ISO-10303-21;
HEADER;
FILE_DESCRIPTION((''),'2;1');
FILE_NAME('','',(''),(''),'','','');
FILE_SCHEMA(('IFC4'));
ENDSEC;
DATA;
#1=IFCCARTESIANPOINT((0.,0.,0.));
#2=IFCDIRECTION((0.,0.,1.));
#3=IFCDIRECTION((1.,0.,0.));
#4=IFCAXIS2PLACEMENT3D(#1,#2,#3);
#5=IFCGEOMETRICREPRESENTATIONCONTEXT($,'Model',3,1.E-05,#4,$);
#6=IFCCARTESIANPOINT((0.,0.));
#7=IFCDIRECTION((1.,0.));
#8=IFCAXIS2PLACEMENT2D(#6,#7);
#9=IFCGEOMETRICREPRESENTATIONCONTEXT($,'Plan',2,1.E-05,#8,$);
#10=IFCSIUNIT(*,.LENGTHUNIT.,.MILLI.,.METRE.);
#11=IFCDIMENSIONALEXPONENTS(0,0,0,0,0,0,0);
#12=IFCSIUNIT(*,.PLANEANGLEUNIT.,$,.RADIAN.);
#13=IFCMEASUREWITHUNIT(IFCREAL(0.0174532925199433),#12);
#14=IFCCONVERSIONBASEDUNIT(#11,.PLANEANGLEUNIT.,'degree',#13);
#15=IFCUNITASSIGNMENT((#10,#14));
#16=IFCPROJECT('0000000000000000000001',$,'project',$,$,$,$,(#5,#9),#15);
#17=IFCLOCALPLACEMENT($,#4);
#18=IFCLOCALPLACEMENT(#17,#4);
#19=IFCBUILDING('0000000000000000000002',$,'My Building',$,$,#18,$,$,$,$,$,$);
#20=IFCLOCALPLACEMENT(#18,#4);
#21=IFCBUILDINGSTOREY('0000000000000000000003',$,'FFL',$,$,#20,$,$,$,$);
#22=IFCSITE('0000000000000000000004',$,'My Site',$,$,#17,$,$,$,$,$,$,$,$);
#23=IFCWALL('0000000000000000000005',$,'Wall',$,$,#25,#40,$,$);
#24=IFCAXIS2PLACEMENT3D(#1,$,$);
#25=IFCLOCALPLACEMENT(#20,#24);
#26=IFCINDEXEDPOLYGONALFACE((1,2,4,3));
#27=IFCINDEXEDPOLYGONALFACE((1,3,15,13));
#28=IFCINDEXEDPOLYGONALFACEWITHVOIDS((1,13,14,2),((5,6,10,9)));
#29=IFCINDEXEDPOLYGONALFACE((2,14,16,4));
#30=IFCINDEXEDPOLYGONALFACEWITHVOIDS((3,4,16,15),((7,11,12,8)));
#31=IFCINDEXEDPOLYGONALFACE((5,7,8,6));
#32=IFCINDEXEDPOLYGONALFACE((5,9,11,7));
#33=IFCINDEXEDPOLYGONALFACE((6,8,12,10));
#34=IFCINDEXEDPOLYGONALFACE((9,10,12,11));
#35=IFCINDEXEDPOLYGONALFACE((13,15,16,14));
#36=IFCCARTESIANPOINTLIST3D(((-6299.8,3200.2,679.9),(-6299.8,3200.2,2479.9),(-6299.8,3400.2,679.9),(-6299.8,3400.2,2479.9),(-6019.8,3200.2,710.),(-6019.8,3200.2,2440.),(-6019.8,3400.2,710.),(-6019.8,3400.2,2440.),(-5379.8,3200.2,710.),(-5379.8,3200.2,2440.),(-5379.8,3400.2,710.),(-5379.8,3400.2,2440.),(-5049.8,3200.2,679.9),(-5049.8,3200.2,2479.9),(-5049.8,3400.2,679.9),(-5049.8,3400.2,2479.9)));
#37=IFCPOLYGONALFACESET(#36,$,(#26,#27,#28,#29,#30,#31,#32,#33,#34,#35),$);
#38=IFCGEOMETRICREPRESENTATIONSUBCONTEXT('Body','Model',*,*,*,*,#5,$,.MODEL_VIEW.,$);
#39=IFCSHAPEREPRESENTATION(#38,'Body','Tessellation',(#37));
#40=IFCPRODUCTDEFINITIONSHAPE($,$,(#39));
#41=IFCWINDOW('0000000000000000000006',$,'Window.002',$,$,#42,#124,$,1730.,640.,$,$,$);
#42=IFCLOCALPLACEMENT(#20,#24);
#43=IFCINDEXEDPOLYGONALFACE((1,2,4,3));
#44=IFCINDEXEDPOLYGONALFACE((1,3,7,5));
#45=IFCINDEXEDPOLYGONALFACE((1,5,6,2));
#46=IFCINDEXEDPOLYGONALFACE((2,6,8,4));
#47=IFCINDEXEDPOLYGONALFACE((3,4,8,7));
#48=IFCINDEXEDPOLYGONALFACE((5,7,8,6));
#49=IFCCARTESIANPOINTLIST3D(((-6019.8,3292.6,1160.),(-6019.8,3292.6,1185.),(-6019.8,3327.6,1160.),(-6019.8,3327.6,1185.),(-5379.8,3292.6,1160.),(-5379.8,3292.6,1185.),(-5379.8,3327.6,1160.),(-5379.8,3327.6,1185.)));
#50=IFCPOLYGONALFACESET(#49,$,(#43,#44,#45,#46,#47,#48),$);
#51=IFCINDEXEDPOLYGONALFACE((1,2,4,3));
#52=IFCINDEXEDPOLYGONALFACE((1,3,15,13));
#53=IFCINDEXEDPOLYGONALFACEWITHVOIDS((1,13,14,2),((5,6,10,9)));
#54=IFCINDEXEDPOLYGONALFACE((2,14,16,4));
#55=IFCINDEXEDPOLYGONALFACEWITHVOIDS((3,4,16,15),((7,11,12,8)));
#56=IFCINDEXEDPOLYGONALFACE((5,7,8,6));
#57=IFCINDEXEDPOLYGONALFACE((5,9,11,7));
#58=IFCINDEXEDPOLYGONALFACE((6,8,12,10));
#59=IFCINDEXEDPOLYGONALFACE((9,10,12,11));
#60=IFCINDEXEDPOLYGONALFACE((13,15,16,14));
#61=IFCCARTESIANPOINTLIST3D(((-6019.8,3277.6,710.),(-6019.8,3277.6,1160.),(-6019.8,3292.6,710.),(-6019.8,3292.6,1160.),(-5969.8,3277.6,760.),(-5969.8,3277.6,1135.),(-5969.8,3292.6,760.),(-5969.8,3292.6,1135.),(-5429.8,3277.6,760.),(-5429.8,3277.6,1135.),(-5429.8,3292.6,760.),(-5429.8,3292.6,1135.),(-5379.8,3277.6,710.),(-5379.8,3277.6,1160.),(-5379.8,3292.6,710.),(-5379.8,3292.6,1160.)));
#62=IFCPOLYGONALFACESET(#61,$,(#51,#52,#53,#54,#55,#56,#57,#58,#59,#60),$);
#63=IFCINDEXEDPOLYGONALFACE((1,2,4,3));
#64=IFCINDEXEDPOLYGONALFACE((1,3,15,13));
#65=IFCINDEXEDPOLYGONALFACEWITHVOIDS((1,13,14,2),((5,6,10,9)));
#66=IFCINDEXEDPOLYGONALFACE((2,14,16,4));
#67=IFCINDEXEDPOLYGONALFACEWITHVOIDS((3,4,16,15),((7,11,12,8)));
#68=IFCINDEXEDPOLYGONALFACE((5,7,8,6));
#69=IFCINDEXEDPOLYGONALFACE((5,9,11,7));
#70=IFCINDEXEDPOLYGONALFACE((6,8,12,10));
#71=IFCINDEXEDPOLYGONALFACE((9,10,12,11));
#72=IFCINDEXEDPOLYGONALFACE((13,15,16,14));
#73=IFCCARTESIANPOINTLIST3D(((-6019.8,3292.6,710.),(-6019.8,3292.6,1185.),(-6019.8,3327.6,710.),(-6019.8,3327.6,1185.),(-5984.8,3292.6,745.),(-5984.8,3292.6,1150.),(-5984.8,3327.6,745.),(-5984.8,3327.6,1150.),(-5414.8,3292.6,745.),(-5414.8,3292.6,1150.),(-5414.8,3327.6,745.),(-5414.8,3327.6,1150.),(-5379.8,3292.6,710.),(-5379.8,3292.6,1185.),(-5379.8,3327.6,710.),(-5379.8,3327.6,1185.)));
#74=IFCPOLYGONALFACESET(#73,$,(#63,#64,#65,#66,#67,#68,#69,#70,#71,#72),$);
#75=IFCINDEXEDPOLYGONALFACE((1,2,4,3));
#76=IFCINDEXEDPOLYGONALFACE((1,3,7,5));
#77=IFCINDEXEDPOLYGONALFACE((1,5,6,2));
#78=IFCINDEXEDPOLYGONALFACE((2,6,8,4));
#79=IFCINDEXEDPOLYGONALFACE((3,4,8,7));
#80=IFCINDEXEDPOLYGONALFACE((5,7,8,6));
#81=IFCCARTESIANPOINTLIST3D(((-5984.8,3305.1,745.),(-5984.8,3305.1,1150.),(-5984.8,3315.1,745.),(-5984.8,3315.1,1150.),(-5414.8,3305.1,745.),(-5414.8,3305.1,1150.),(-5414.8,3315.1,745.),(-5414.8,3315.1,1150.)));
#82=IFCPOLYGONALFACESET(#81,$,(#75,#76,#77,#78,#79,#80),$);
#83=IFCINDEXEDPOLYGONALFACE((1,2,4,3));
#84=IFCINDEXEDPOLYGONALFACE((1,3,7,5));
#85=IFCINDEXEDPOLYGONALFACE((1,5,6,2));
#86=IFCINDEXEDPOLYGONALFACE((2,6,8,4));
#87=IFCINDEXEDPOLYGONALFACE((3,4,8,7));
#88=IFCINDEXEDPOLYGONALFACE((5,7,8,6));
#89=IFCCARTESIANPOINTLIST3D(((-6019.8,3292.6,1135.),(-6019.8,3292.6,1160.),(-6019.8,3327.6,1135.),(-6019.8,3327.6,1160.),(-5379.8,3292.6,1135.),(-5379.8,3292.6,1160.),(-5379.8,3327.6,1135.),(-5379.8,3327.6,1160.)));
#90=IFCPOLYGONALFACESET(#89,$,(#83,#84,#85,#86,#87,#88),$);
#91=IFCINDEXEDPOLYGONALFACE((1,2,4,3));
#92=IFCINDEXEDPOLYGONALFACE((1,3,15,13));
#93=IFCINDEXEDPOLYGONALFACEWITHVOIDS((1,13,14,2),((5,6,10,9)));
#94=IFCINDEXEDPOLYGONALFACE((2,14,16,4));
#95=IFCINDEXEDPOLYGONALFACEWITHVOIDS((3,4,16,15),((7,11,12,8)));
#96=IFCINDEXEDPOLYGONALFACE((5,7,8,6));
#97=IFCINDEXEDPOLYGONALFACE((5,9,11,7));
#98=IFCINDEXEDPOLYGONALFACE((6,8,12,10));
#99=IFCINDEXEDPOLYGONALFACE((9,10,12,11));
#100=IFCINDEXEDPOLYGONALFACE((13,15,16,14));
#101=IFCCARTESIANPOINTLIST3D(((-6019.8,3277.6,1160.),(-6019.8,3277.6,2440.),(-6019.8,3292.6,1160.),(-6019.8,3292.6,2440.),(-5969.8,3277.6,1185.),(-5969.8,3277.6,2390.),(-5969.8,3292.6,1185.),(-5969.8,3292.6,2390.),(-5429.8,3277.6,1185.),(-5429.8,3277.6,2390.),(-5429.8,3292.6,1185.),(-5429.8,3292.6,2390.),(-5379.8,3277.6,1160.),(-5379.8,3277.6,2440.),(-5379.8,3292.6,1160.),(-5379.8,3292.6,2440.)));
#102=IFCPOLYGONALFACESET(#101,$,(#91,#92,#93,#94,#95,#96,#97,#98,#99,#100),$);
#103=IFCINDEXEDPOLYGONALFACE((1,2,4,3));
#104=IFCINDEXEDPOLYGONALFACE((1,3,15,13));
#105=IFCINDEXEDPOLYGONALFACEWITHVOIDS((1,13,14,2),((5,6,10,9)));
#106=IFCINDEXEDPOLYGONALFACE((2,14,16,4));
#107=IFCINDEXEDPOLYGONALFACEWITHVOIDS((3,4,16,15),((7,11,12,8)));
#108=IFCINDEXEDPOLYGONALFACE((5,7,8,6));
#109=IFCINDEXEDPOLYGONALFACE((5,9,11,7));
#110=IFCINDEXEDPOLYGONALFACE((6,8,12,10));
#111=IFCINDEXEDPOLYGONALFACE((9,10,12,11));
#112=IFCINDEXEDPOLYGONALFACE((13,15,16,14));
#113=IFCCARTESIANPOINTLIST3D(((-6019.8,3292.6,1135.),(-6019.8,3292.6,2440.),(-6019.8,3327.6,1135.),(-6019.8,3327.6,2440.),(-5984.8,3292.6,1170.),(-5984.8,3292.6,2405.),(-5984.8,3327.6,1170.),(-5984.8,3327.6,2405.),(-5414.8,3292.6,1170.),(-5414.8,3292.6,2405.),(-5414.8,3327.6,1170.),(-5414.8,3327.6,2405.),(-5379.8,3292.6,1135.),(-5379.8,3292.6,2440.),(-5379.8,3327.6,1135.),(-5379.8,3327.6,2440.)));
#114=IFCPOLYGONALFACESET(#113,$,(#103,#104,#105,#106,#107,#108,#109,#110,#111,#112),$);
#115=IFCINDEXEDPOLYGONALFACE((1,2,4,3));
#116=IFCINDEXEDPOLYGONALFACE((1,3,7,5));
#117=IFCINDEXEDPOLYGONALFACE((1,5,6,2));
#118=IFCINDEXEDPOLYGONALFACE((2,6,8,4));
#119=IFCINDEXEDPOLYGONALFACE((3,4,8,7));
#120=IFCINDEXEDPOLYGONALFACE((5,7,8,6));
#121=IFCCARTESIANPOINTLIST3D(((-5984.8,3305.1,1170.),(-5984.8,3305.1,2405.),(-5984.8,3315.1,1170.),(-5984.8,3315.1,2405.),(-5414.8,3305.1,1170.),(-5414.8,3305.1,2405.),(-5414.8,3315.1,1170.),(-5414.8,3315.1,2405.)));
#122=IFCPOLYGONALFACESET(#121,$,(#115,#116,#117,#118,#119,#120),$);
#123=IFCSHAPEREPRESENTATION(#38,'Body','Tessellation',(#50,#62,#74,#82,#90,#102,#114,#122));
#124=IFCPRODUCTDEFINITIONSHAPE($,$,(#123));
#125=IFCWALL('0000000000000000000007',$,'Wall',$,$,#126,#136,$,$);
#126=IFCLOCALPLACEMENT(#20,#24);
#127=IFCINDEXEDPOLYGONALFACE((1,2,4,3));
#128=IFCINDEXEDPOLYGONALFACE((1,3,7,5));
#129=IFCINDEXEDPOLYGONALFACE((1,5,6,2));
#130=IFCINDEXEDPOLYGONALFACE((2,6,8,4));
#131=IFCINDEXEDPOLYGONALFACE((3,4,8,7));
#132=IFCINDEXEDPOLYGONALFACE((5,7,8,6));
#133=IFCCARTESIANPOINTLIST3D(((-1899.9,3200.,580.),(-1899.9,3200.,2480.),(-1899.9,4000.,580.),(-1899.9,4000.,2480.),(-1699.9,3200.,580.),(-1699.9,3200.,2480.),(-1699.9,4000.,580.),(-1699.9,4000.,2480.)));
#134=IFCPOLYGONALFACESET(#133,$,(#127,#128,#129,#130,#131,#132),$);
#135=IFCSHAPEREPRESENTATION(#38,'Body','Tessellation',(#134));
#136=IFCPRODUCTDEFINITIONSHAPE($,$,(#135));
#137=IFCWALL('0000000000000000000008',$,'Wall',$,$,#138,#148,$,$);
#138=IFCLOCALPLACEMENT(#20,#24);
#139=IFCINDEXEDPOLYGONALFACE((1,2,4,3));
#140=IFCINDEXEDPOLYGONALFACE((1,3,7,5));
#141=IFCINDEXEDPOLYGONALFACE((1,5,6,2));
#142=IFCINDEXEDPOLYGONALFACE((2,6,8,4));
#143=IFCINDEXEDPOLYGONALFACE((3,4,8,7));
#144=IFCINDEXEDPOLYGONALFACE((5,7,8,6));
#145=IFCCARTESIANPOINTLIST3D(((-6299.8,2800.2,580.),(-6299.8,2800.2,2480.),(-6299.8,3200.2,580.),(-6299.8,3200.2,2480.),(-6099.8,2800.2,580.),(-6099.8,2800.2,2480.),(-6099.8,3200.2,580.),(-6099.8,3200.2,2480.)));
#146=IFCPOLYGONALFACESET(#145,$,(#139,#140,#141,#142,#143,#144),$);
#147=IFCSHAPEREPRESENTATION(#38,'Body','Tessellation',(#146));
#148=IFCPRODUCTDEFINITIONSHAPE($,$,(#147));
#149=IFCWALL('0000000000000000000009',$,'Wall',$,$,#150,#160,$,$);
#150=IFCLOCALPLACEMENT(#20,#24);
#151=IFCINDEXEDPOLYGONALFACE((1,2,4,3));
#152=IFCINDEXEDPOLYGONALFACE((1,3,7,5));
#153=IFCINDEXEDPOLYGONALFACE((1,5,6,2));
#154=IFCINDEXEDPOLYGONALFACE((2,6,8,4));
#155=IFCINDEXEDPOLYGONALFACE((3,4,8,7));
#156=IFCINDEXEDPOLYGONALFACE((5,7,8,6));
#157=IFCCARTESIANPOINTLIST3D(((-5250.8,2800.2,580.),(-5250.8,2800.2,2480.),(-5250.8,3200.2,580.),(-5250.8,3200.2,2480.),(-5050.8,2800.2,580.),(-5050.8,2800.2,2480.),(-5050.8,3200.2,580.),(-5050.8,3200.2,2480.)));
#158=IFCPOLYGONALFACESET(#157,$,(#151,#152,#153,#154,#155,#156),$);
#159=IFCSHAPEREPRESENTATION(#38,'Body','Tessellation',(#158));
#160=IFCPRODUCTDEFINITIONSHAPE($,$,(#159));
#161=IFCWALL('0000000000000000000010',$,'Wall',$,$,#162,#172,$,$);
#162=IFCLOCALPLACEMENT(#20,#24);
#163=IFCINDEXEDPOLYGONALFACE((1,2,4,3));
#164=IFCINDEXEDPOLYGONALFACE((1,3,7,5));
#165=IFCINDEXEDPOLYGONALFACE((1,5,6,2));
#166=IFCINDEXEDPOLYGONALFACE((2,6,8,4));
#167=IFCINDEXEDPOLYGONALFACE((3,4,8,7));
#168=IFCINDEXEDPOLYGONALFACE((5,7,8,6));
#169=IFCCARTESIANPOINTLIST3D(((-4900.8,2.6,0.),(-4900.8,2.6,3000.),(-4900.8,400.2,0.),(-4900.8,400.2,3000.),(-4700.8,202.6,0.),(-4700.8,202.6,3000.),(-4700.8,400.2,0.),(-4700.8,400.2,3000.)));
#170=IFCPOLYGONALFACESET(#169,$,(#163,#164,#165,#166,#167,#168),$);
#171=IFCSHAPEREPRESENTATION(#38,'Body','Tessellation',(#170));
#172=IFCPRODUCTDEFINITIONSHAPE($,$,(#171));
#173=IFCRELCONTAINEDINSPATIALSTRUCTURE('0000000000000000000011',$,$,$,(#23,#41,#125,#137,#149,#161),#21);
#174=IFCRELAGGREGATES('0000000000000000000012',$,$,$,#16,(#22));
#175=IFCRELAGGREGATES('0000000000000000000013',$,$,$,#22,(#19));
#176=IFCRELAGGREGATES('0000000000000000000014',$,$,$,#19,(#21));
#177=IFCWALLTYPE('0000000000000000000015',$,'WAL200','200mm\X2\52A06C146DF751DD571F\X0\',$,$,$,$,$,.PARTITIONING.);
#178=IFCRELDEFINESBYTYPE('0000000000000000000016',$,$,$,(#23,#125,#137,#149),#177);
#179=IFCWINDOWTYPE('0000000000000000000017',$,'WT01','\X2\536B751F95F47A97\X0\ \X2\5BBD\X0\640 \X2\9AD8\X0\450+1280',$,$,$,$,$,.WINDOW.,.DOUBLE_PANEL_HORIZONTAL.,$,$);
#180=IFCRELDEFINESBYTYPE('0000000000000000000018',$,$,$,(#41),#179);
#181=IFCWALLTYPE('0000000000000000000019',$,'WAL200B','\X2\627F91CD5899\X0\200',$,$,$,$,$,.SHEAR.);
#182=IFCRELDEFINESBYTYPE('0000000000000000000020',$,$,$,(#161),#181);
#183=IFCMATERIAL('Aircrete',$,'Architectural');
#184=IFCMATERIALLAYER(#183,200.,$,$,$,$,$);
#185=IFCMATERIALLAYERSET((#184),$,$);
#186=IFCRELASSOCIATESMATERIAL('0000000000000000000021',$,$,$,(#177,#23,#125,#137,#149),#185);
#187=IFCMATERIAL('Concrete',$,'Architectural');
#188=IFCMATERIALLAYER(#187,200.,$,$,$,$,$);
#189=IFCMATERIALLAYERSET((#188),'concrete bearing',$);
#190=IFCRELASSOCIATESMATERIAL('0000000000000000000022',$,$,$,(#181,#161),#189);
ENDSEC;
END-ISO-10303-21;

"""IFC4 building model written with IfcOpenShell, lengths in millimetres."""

from ifc_helpers import new_model, entity, si_unit, converted_unit, frame, origin_with_axes, origin_2d_with_axis, place, context, subcontext, project, spatial, line, indexed_curve, outline, extrude, shape, source, transform, mapped, material, layer, layer_set, layer_usage, type_object, type_shapes, element, fill, save


model = new_model("IFC4")

# Units and contexts
model_context = context("Model", 3, precision=1e-05, world=origin_with_axes())
plan_context = context("Plan", 2, precision=1e-05, world=origin_2d_with_axis())
body_context_1 = subcontext(model_context, "Body", "Model", "MODEL_VIEW")
body_context_2 = subcontext(plan_context, "Body", "Plan", "PLAN_VIEW")
ifc_project = project(units=[si_unit("LENGTHUNIT", "METRE", prefix="MILLI"), converted_unit("PLANEANGLEUNIT", "degree", entity("IfcReal", 0.0174532925199433), si_unit("PLANEANGLEUNIT", "RADIAN"), dimensions=[0, 0, 0, 0, 0, 0, 0])], contexts=[model_context, plan_context])

# Site, building, storey
site_placement = place(None, origin_with_axes())
site = spatial("IfcSite", under=ifc_project, at=site_placement, Name="My Site")
building_placement = place(site_placement, origin_with_axes())
building = spatial("IfcBuilding", under=site, at=building_placement, Name="My Building")
storey_placement = place(building_placement, origin_with_axes())
storey = spatial("IfcBuildingStorey", under=building, at=storey_placement, Name="FFL")

# Shared definitions
ifc_material_1 = material(Name="Aircrete", Category="Architectural")

# Shared definitions
ifc_layer_1 = layer(ifc_material_1, 200.0)
ifc_layer_set_1 = layer_set([ifc_layer_1])
wall_type_1 = type_object("IfcWallType", Name="WAL200", Description="200mm加气混凝土", PredefinedType="PARTITIONING", material=ifc_layer_set_1)

# Wall, opening, window
ifc_layer_usage_1 = layer_usage(ifc_layer_set_1, "AXIS2", "NEGATIVE", 0.0)
wall_1_placement = place(storey_placement, frame((-6299.8, 3400.2, 679.9), z_axis=(0.0, 0.0, 1.0), x_axis=(1.0, 0.0, 0.0)))
wall_1 = element("IfcWall", 1, at=wall_1_placement, inside=storey, type_object=wall_type_1, material=ifc_layer_usage_1, Name="Wall", context=body_context_1, shape_type="SweptSolid", body=[
    extrude(outline(indexed_curve([(0.0, -200.0), (0.0, 0.0), (1250.0, 0.0), (1250.0, -200.0)], segments=[line(1, 2, 3, 4, 1)])), origin_with_axes(), (0.0, 0.0, 1.0), 1800.0),
])
shared_shape_1 = source(origin_with_axes(), body_context_1, "Body", "SweptSolid", [
    extrude(outline(indexed_curve([(0.0, 0.0), (640.0, 0.0), (640.0, 1730.0), (0.0, 1730.0)], segments=[line(1, 2, 3, 4, 1)])), frame((0.0, -600.0, 0.0), z_axis=(0.0, -1.0, 0.0), x_axis=(1.0, 0.0, 0.0)), (0.0, 0.0, -1.0), 1200.0),
])
opening_1_placement = place(wall_1_placement, frame((280.0, -172.6, 30.1), z_axis=(0.0, 0.0, 1.0), x_axis=(1.0, 0.0, 0.0)))
opening_1 = element("IfcOpeningElement", 2, at=opening_1_placement, cuts=wall_1, PredefinedType="OPENING", context=body_context_1, shape_type="MappedRepresentation", body=[
    mapped(shared_shape_1, transform((0.0, 0.0, 0.0), x_axis=(1.0, 0.0, 0.0), y_axis=(0.0, 1.0, 0.0), z_axis=(0.0, 0.0, 1.0), scale=1.0)),
])
window_type_1 = type_object("IfcWindowType", Name="WT01", Description="卫生间窗 宽640 高450+1280", PartitioningType="DOUBLE_PANEL_HORIZONTAL", PredefinedType="WINDOW")
shared_shape_2 = source(origin_with_axes(), body_context_1, "Body", "SweptSolid", [
    extrude(outline(indexed_curve([(0.0, 450.0), (640.0, 450.0), (640.0, 475.0), (0.0, 475.0)], segments=[line(1, 2, 3, 4, 1)])), frame((0.0, 65.0, 0.0), z_axis=(0.0, -1.0, 0.0), x_axis=(1.0, 0.0, 0.0)), (0.0, 0.0, -1.0), 35.0),
    extrude(outline(indexed_curve([(0.0, 0.0), (640.0, 0.0), (640.0, 450.0), (0.0, 450.0)], segments=[line(1, 2, 3, 4, 1)]), holes=[indexed_curve([(50.0, 50.0), (590.0, 50.0), (590.0, 425.0), (50.0, 425.0)], segments=[line(1, 2, 3, 4, 1)])]), frame((0.0, 50.0, 0.0), z_axis=(0.0, -1.0, 0.0), x_axis=(1.0, 0.0, 0.0)), (0.0, 0.0, -1.0), 15.0),
    extrude(outline(indexed_curve([(0.0, 0.0), (640.0, 0.0), (640.0, 475.0), (0.0, 475.0)], segments=[line(1, 2, 3, 4, 1)]), holes=[indexed_curve([(35.0, 35.0), (605.0, 35.0), (605.0, 440.0), (35.0, 440.0)], segments=[line(1, 2, 3, 4, 1)])]), frame((0.0, 65.0, 0.0), z_axis=(0.0, -1.0, 0.0), x_axis=(1.0, 0.0, 0.0)), (0.0, 0.0, -1.0), 35.0),
    extrude(outline(indexed_curve([(35.0, 35.0), (605.0, 35.0), (605.0, 440.0), (35.0, 440.0)], segments=[line(1, 2, 3, 4, 1)])), frame((0.0, 77.5, 0.0), z_axis=(0.0, -1.0, 0.0), x_axis=(1.0, 0.0, 0.0)), (0.0, 0.0, -1.0), 10.0),
    extrude(outline(indexed_curve([(640.0, 0.0), (0.0, 0.0), (0.0, -25.0), (640.0, -25.0)], segments=[line(1, 2, 3, 4, 1)])), frame((0.0, 65.0, 450.0), z_axis=(0.0, -1.0, 0.0), x_axis=(1.0, 0.0, 0.0)), (0.0, 0.0, -1.0), 35.0),
    extrude(outline(indexed_curve([(0.0, 0.0), (640.0, 0.0), (640.0, 1280.0), (0.0, 1280.0), (0.0, 0.0)]), holes=[indexed_curve([(50.0, 25.0), (590.0, 25.0), (590.0, 1230.0), (50.0, 1230.0), (50.0, 25.0)])]), frame((0.0, 50.0, 450.0), z_axis=(0.0, -1.0, 0.0), x_axis=(1.0, 0.0, 0.0)), (0.0, 0.0, -1.0), 15.0),
    extrude(outline(indexed_curve([(0.0, 0.0), (640.0, 0.0), (640.0, 1305.0), (0.0, 1305.0)], segments=[line(1, 2, 3, 4, 1)]), holes=[indexed_curve([(35.0, 35.0), (605.0, 35.0), (605.0, 1270.0), (35.0, 1270.0)], segments=[line(1, 2, 3, 4, 1)])]), frame((0.0, 65.0, 425.0), z_axis=(0.0, -1.0, 0.0), x_axis=(1.0, 0.0, 0.0)), (0.0, 0.0, -1.0), 35.0),
    extrude(outline(indexed_curve([(35.0, 35.0), (605.0, 35.0), (605.0, 1270.0), (35.0, 1270.0)], segments=[line(1, 2, 3, 4, 1)])), frame((0.0, 77.5, 425.0), z_axis=(0.0, -1.0, 0.0), x_axis=(1.0, 0.0, 0.0)), (0.0, 0.0, -1.0), 10.0),
])
shared_shape_3 = source(origin_with_axes(), body_context_2, "Body", "Curve2D", [
    entity("IfcIndexedPolyCurve", entity("IfcCartesianPointList2D", [[50.0, 50.0], [590.0, 50.0]])),
    entity("IfcIndexedPolyCurve", entity("IfcCartesianPointList2D", [[0.0, 100.0], [0.0, 100.0], [0.0, 65.0], [50.0, 65.0], [50.0, 50.0], [0.0, 50.0]]), [entity("IfcLineIndex", [1, 2, 3, 4, 5, 6, 1])]),
    entity("IfcIndexedPolyCurve", entity("IfcCartesianPointList2D", [[640.0, 100.0], [640.0, 100.0], [640.0, 65.0], [590.0, 65.0], [590.0, 50.0], [640.0, 50.0]]), [entity("IfcLineIndex", [1, 2, 3, 4, 5, 6, 1])]),
    entity("IfcIndexedPolyCurve", entity("IfcCartesianPointList2D", [[0.0, 65.0], [35.0, 65.0], [35.0, 100.0], [0.0, 100.0]]), [entity("IfcLineIndex", [1, 2, 3, 4, 1])]),
    entity("IfcIndexedPolyCurve", entity("IfcCartesianPointList2D", [[640.0, 65.0], [605.0, 65.0], [605.0, 100.0], [640.0, 100.0]]), [entity("IfcLineIndex", [1, 2, 3, 4, 1])]),
    entity("IfcIndexedPolyCurve", entity("IfcCartesianPointList2D", [[35.0, 65.0], [605.0, 65.0]])),
    entity("IfcIndexedPolyCurve", entity("IfcCartesianPointList2D", [[35.0, 100.0], [605.0, 100.0]])),
    entity("IfcIndexedPolyCurve", entity("IfcCartesianPointList2D", [[35.0, 82.5], [605.0, 82.5]])),
])
type_shapes(window_type_1, [shared_shape_2, shared_shape_3])
window_1_placement = place(opening_1_placement, origin_with_axes())
window_1 = element("IfcWindow", 3, at=window_1_placement, inside=storey, type_object=window_type_1, Name="Window.002", OverallHeight=1730.0, OverallWidth=640.0, shapes=[
    shape(body_context_1, "Body", "MappedRepresentation", [mapped(shared_shape_2, transform((0.0, 0.0, 0.0), x_axis=(1.0, 0.0, 0.0), y_axis=(0.0, 1.0, 0.0), z_axis=(0.0, 0.0, 1.0), scale=1.0))]),
    shape(body_context_2, "Body", "MappedRepresentation", [mapped(shared_shape_3, transform((0.0, 0.0, 0.0), x_axis=(1.0, 0.0, 0.0), y_axis=(0.0, 1.0, 0.0), z_axis=(0.0, 0.0, 1.0), scale=1.0))]),
])
fill(opening_1, window_1)

# Walls
ifc_layer_usage_2 = layer_usage(ifc_layer_set_1, "AXIS2", "NEGATIVE", 0.0)
wall_2_placement = place(storey_placement, frame((-1899.9, 3200.0, 580.0), z_axis=(0.0, 0.0, 1.0), x_axis=(0.0, 1.0, 0.0)))
element("IfcWall", 4, at=wall_2_placement, inside=storey, type_object=wall_type_1, material=ifc_layer_usage_2, Name="Wall", context=body_context_1, shape_type="SweptSolid", body=[
    extrude(outline(indexed_curve([(0.0, -200.0), (0.0, 0.0), (800.0, 0.0), (800.0, -200.0)], segments=[line(1, 2, 3, 4, 1)])), origin_with_axes(), (0.0, 0.0, 1.0), 1900.0),
])
ifc_layer_usage_3 = layer_usage(ifc_layer_set_1, "AXIS2", "NEGATIVE", 0.0)
wall_3_placement = place(storey_placement, frame((-6299.8, 2800.2, 580.0), z_axis=(0.0, 0.0, 1.0), x_axis=(0.0, 1.0, 0.0)))
element("IfcWall", 5, at=wall_3_placement, inside=storey, type_object=wall_type_1, material=ifc_layer_usage_3, Name="Wall", context=body_context_1, shape_type="SweptSolid", body=[
    extrude(outline(indexed_curve([(0.0, -200.0), (0.0, 0.0), (400.0, 0.0), (400.0, -200.0)], segments=[line(1, 2, 3, 4, 1)])), origin_with_axes(), (0.0, 0.0, 1.0), 1900.0),
])
ifc_layer_usage_4 = layer_usage(ifc_layer_set_1, "AXIS2", "NEGATIVE", 0.0)
wall_4_placement = place(storey_placement, frame((-5250.8, 2800.2, 580.0), z_axis=(0.0, 0.0, 1.0), x_axis=(0.0, 1.0, 0.0)))
element("IfcWall", 6, at=wall_4_placement, inside=storey, type_object=wall_type_1, material=ifc_layer_usage_4, Name="Wall", context=body_context_1, shape_type="SweptSolid", body=[
    extrude(outline(indexed_curve([(0.0, -200.0), (0.0, 0.0), (400.0, 0.0), (400.0, -200.0)], segments=[line(1, 2, 3, 4, 1)])), origin_with_axes(), (0.0, 0.0, 1.0), 1900.0),
])

# Wall
ifc_material_2 = material(Name="Concrete", Category="Architectural")
ifc_layer_2 = layer(ifc_material_2, 200.0)
ifc_layer_set_2 = layer_set([ifc_layer_2], Name="concrete bearing")
ifc_layer_usage_5 = layer_usage(ifc_layer_set_2, "AXIS2", "NEGATIVE", 0.0)
wall_type_2 = type_object("IfcWallType", Name="WAL200B", Description="承重墙200", PredefinedType="SHEAR", material=ifc_layer_set_2)
wall_5_placement = place(storey_placement, frame((-4700.8, 400.2, 0.0), z_axis=(0.0, 0.0, 1.0), x_axis=(0.0, -1.0, 0.0)))
element("IfcWall", 7, at=wall_5_placement, inside=storey, type_object=wall_type_2, material=ifc_layer_usage_5, Name="Wall", context=body_context_1, shape_type="SweptSolid", body=[
    extrude(outline(indexed_curve([(0.0, -200.0), (0.0, 0.0), (197.6, 0.0), (397.6, -200.0)], segments=[line(1, 2, 3, 4, 1)])), origin_with_axes(), (0.0, 0.0, 1.0), 3000.0),
])

save(model, "model.ifc")
